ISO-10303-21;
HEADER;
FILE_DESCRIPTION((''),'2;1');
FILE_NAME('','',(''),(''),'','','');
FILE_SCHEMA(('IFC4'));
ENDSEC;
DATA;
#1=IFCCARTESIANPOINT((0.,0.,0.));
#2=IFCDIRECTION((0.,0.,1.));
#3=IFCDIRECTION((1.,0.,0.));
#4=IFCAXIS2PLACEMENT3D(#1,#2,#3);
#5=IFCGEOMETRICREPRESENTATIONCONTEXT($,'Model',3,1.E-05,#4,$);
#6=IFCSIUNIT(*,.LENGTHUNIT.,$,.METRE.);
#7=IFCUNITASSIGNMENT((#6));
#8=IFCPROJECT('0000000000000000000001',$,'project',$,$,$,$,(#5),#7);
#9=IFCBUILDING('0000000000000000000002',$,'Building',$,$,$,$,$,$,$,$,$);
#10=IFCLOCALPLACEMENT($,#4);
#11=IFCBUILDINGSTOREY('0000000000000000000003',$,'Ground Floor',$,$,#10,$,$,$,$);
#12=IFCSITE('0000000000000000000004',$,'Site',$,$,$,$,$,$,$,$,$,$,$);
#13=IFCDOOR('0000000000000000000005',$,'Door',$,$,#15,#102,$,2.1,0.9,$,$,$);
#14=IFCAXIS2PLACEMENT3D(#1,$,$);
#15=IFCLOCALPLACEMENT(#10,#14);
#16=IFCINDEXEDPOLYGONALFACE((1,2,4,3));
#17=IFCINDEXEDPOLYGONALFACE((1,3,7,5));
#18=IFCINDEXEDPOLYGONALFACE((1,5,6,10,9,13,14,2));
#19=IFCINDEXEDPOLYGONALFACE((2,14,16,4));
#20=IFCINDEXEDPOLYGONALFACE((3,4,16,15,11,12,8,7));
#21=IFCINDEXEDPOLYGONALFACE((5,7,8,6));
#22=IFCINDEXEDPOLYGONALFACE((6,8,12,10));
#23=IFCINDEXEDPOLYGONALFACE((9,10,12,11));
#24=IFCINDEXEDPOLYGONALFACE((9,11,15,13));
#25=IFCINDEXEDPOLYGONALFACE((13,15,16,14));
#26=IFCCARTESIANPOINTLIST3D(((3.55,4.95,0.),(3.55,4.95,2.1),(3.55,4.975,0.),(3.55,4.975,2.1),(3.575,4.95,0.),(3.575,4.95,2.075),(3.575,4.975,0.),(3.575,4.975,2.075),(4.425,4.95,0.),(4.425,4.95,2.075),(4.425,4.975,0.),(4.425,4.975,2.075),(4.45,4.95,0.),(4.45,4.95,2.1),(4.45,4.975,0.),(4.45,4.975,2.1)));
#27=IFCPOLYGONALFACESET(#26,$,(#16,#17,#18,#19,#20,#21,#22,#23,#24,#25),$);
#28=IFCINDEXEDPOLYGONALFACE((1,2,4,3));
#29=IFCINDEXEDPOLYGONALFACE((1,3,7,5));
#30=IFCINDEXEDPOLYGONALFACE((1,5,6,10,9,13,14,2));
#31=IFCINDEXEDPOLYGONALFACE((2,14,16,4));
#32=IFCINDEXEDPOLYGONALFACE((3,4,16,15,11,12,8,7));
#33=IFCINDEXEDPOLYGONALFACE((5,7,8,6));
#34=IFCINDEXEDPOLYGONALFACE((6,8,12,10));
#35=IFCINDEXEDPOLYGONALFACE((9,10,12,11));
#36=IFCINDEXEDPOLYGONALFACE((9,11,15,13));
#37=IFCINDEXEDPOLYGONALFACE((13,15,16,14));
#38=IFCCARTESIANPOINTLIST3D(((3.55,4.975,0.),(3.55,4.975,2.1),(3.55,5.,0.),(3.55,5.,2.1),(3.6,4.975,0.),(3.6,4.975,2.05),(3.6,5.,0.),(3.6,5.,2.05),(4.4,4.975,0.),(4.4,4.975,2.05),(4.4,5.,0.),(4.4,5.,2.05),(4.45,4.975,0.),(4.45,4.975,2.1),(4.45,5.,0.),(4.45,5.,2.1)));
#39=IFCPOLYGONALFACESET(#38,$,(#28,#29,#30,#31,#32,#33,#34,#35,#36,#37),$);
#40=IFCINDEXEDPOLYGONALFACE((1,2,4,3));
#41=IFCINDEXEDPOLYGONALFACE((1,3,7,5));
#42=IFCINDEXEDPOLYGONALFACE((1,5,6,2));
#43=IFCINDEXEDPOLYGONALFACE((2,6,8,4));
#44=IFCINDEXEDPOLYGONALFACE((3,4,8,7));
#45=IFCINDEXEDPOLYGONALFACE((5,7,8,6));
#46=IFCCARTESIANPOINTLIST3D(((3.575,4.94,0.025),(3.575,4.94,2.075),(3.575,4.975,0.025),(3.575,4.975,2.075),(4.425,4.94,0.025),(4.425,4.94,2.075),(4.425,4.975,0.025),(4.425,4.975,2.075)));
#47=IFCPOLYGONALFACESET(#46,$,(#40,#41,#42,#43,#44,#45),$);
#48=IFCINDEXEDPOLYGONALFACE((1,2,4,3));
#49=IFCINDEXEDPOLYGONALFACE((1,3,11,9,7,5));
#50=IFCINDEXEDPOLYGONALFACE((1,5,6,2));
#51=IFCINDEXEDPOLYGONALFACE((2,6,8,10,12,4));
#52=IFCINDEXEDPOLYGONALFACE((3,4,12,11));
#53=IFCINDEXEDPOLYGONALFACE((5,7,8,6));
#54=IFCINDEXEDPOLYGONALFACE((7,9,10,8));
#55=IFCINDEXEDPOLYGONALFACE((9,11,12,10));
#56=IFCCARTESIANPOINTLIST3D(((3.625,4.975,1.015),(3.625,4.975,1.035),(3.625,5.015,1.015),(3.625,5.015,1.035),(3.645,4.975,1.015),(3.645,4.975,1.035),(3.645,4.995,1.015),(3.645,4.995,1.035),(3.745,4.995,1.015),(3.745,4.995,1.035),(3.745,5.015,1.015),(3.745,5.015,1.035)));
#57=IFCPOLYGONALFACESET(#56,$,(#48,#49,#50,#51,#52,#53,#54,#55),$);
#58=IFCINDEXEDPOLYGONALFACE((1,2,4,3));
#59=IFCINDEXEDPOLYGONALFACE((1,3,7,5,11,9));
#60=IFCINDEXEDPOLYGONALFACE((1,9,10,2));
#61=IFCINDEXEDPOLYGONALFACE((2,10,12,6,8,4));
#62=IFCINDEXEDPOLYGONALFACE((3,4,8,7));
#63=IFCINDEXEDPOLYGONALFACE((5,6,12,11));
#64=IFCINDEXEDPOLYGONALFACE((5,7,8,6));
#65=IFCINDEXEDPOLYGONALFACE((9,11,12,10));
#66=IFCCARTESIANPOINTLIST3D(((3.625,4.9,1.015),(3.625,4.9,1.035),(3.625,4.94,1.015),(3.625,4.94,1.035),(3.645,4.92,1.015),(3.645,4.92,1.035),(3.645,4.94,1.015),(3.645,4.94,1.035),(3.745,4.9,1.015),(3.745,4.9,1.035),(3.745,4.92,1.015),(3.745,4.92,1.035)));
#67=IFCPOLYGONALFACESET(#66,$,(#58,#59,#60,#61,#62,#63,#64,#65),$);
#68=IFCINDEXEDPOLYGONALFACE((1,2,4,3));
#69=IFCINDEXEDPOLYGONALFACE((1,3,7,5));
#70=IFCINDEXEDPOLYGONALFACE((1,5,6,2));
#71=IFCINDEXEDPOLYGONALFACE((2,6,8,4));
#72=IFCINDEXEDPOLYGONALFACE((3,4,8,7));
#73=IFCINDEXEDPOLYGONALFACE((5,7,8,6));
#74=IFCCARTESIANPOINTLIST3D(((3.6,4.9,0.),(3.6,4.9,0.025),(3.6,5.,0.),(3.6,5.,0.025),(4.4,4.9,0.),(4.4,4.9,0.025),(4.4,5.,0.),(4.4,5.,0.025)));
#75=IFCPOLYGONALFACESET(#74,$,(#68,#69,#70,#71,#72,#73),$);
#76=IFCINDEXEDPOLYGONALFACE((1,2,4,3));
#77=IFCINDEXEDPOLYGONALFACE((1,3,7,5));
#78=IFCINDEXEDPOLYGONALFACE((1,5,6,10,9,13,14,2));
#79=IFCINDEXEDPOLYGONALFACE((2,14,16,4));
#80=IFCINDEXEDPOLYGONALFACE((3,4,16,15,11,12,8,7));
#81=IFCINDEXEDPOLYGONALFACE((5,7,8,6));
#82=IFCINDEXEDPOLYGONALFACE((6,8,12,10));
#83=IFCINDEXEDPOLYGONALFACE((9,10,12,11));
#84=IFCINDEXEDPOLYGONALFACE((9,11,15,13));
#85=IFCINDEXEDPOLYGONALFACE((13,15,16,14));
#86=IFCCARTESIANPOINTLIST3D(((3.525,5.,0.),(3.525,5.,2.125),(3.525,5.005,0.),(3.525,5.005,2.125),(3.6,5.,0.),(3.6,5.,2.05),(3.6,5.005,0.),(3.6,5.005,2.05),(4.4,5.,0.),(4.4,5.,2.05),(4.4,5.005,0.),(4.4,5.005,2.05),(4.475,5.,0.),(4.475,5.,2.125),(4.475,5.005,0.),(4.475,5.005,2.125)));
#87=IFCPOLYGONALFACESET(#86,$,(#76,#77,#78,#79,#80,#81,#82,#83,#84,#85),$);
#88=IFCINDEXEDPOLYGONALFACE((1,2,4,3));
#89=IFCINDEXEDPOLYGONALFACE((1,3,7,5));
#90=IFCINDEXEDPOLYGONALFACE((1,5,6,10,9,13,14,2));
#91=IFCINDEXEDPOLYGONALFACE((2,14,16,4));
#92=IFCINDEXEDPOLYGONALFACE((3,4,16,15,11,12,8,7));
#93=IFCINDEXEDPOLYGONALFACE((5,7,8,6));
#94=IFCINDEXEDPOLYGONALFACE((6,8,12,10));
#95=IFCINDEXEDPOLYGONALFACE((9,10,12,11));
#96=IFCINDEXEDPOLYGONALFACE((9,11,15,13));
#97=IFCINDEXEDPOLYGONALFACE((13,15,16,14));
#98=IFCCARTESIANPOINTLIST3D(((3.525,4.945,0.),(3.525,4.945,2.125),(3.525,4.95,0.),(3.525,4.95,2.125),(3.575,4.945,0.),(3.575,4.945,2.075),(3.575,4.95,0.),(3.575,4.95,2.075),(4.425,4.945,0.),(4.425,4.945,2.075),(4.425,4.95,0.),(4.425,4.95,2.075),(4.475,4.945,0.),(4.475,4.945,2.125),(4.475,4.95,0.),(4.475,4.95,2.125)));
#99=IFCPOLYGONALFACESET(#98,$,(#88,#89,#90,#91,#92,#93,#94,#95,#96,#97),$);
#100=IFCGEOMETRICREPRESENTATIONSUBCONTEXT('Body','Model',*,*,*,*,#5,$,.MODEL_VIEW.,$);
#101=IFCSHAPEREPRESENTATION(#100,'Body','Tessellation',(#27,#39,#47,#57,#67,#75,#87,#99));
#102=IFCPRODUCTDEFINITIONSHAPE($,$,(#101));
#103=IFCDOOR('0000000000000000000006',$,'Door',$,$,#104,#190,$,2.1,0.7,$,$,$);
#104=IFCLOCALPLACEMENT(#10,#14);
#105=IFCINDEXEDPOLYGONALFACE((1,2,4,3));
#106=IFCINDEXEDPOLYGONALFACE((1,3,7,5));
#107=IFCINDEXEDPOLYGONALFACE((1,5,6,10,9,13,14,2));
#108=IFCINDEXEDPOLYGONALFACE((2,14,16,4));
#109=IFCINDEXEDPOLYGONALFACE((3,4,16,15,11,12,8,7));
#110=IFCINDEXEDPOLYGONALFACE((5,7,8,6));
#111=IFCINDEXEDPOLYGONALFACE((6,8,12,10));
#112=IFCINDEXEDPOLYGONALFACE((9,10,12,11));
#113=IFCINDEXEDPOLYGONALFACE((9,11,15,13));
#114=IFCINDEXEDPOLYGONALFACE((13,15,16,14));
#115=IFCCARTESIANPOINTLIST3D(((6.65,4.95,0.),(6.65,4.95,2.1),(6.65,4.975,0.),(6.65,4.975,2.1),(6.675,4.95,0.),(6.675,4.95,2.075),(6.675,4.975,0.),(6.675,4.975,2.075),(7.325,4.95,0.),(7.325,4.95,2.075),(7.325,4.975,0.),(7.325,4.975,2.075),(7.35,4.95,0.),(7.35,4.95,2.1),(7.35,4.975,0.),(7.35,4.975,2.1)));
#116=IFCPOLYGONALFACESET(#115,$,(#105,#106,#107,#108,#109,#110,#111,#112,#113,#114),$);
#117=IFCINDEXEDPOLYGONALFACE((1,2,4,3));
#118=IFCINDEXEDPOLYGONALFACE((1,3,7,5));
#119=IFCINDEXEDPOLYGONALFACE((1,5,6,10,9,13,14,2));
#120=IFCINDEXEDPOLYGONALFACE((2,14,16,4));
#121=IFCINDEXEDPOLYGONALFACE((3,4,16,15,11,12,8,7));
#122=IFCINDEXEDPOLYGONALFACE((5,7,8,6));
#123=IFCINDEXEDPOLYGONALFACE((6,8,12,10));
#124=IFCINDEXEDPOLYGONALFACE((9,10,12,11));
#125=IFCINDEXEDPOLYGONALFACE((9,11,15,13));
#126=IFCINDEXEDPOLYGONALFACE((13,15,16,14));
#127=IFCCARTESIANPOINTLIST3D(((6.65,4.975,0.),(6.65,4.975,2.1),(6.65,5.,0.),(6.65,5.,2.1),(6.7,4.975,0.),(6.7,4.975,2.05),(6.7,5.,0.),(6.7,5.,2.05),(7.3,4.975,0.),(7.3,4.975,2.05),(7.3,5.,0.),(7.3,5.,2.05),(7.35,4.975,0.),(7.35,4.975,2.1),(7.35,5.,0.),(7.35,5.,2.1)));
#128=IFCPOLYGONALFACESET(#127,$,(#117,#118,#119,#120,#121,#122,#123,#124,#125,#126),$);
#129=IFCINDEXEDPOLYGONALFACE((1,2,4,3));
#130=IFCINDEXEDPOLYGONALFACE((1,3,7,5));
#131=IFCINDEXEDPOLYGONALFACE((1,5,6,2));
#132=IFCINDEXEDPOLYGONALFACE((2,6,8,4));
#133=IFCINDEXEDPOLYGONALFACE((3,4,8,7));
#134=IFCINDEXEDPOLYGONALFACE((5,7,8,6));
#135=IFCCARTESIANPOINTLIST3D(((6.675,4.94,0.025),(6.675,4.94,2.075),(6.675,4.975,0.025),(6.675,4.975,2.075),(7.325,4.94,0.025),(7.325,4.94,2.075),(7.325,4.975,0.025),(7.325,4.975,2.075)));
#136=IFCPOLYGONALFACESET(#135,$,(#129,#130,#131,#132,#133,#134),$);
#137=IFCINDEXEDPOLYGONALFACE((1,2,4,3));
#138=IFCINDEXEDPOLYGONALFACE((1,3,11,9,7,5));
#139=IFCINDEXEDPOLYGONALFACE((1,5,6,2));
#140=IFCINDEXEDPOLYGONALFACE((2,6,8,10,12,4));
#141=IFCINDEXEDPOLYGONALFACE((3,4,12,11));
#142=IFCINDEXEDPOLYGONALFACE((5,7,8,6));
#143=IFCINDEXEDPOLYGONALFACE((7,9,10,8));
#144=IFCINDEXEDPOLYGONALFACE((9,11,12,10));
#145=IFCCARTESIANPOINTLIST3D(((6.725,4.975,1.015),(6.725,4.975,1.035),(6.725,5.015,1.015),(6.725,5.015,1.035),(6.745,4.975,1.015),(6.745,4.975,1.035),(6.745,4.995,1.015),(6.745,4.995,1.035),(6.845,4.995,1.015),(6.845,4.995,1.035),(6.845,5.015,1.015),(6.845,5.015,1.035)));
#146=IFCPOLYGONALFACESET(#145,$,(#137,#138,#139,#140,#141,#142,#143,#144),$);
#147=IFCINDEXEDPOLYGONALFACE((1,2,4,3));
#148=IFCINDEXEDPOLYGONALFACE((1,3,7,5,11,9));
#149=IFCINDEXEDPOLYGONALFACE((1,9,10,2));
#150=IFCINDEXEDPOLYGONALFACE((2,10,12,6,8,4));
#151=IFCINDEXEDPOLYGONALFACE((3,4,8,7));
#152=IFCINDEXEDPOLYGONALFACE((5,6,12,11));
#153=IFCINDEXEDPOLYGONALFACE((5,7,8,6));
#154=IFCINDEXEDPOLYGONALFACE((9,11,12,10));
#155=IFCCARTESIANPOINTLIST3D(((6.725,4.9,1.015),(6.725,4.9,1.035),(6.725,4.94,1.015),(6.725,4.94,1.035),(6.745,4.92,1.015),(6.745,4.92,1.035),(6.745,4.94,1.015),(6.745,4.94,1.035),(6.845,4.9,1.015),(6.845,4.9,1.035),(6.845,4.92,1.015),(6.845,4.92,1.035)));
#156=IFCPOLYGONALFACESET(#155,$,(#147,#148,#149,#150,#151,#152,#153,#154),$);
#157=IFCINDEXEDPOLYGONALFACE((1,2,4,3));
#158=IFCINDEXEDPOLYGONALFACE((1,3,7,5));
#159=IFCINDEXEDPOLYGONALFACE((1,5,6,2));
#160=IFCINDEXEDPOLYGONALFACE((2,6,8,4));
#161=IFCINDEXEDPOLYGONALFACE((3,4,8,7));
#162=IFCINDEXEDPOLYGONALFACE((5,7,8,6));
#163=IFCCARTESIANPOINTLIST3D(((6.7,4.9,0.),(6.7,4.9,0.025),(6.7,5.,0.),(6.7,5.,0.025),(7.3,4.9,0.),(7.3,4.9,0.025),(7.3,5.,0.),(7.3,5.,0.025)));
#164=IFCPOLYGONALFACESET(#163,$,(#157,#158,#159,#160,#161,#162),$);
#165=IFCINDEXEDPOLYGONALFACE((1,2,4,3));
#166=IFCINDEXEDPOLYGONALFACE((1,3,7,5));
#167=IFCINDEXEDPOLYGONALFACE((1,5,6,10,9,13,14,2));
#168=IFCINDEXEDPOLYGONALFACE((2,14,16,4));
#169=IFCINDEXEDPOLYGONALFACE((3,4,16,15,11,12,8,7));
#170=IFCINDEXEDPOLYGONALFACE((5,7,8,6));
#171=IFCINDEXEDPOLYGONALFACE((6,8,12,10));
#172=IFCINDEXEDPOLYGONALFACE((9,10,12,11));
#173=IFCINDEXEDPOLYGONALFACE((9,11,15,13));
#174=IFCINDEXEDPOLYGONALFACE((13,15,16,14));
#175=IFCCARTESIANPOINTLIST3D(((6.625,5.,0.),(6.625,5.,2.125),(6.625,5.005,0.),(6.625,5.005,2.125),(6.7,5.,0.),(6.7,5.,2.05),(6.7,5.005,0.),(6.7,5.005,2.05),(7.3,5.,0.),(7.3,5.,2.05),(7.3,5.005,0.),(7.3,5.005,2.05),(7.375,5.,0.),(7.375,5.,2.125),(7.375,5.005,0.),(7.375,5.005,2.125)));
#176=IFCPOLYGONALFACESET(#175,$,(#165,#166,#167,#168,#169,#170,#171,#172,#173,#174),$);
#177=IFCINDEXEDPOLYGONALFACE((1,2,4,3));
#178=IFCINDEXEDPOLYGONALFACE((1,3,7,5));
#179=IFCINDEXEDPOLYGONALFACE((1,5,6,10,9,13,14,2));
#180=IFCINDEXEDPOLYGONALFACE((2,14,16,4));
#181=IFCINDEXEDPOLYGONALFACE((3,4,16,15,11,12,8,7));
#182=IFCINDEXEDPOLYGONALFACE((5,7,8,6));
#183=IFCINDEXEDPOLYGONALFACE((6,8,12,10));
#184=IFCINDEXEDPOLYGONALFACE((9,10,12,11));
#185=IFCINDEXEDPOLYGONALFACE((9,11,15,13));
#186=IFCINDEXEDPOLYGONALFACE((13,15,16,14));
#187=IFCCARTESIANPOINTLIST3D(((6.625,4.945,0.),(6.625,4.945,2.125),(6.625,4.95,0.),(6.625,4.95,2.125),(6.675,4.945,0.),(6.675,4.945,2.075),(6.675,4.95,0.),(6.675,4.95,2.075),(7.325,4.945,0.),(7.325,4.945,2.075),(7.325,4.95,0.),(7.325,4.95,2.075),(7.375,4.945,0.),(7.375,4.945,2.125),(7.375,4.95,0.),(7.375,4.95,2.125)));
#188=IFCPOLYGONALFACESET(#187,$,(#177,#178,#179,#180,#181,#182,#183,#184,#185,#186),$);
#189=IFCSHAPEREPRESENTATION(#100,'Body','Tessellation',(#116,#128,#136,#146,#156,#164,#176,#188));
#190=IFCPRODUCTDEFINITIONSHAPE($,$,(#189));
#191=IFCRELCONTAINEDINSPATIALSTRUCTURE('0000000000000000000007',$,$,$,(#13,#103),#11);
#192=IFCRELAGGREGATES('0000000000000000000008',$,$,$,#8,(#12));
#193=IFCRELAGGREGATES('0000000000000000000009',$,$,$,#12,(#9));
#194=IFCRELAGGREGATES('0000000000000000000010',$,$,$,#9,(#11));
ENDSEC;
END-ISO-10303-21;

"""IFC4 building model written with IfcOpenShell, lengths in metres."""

from ifc_helpers import new_model, si_unit, frame, origin_with_axes, place, context, subcontext, project, spatial, line, indexed_curve, outline, extrude, element, save


model = new_model("IFC4")

# Units and contexts
model_context = context("Model", 3, precision=1e-05, world=origin_with_axes())
body_context = subcontext(model_context, "Body", "Model", "MODEL_VIEW")
ifc_project = project(units=[si_unit("LENGTHUNIT", "METRE")], contexts=[model_context])

# Site, building, storey
site = spatial("IfcSite", under=ifc_project, Name="Site")
building = spatial("IfcBuilding", under=site, Name="Building")
storey_placement = place(None, origin_with_axes())
storey = spatial("IfcBuildingStorey", under=building, at=storey_placement, Name="Ground Floor")

# Doors
door_1_placement = place(storey_placement, frame((4.45, 5.0, 0.0), z_axis=(0.0, 0.0, 1.0), x_axis=(-1.0, 0.0, 0.0)))
element("IfcDoor", 1, at=door_1_placement, inside=storey, Name="Door", OverallHeight=2.1, OverallWidth=0.9, context=body_context, shape_type="SweptSolid", body=[
    extrude(outline(indexed_curve([(0.0, 0.0), (0.0, 2.1), (0.9, 2.1), (0.9, 0.0), (0.875, 0.0), (0.875, 2.075), (0.025, 2.075), (0.025, 0.0)], segments=[line(1, 2, 3, 4, 5, 6, 7, 8, 1)])), frame((0.0, 0.025, 0.0), z_axis=(0.0, -1.0, 0.0), x_axis=(1.0, 0.0, 0.0)), (0.0, 0.0, -1.0), 0.025),
    extrude(outline(indexed_curve([(0.0, 0.0), (0.0, 2.1), (0.9, 2.1), (0.9, 0.0), (0.85, 0.0), (0.85, 2.05), (0.05, 2.05), (0.05, 0.0)], segments=[line(1, 2, 3, 4, 5, 6, 7, 8, 1)])), frame((0.0, 0.0, 0.0), z_axis=(0.0, -1.0, 0.0), x_axis=(1.0, 0.0, 0.0)), (0.0, 0.0, -1.0), 0.025),
    extrude(outline(indexed_curve([(0.0, 0.0), (0.85, 0.0), (0.85, 0.035), (0.0, 0.035)], segments=[line(1, 2, 3, 4, 1)])), frame((0.025, 0.025, 0.025), z_axis=(0.0, 0.0, 1.0), x_axis=(1.0, 0.0, 0.0)), (0.0, 0.0, 1.0), 2.05),
    extrude(outline(indexed_curve([(0.0, 0.0), (0.0, -0.04), (-0.12, -0.04), (-0.12, -0.02), (-0.02, -0.02), (-0.02, 0.0)], segments=[line(1, 2, 3, 4, 5, 6, 1)])), frame((0.825, 0.025, 1.015), z_axis=(0.0, 0.0, 1.0), x_axis=(1.0, 0.0, 0.0)), (0.0, 0.0, 1.0), 0.02),
    extrude(outline(indexed_curve([(0.0, 0.0), (0.0, 0.04), (-0.12, 0.04), (-0.12, 0.02), (-0.02, 0.02), (-0.02, 0.0)], segments=[line(1, 2, 3, 4, 5, 6, 1)])), frame((0.825, 0.06, 1.015), z_axis=(0.0, 0.0, 1.0), x_axis=(1.0, 0.0, 0.0)), (0.0, 0.0, 1.0), 0.02),
    extrude(outline(indexed_curve([(0.0, 0.0), (0.8, 0.0), (0.8, 0.1), (0.0, 0.1)], segments=[line(1, 2, 3, 4, 1)])), frame((0.05, 0.0, 0.0), z_axis=(0.0, 0.0, 1.0), x_axis=(1.0, 0.0, 0.0)), (0.0, 0.0, 1.0), 0.025),
    extrude(outline(indexed_curve([(0.0, 0.0), (0.0, 2.125), (0.95, 2.125), (0.95, 0.0), (0.875, 0.0), (0.875, 2.05), (0.075, 2.05), (0.075, 0.0)], segments=[line(1, 2, 3, 4, 5, 6, 7, 8, 1)])), frame((-0.025, -0.005, 0.0), z_axis=(0.0, -1.0, 0.0), x_axis=(1.0, 0.0, 0.0)), (0.0, 0.0, -1.0), 0.005),
    extrude(outline(indexed_curve([(0.0, 0.0), (0.0, 2.125), (0.95, 2.125), (0.95, 0.0), (0.9, 0.0), (0.9, 2.075), (0.05, 2.075), (0.05, 0.0)], segments=[line(1, 2, 3, 4, 5, 6, 7, 8, 1)])), frame((-0.025, 0.05, 0.0), z_axis=(0.0, -1.0, 0.0), x_axis=(1.0, 0.0, 0.0)), (0.0, 0.0, -1.0), 0.005),
])
door_2_placement = place(storey_placement, frame((7.35, 5.0, 0.0), z_axis=(0.0, 0.0, 1.0), x_axis=(-1.0, 0.0, 0.0)))
element("IfcDoor", 2, at=door_2_placement, inside=storey, Name="Door", OverallHeight=2.1, OverallWidth=0.7, context=body_context, shape_type="SweptSolid", body=[
    extrude(outline(indexed_curve([(0.0, 0.0), (0.0, 2.1), (0.7, 2.1), (0.7, 0.0), (0.675, 0.0), (0.675, 2.075), (0.025, 2.075), (0.025, 0.0)], segments=[line(1, 2, 3, 4, 5, 6, 7, 8, 1)])), frame((0.0, 0.025, 0.0), z_axis=(0.0, -1.0, 0.0), x_axis=(1.0, 0.0, 0.0)), (0.0, 0.0, -1.0), 0.025),
    extrude(outline(indexed_curve([(0.0, 0.0), (0.0, 2.1), (0.7, 2.1), (0.7, 0.0), (0.65, 0.0), (0.65, 2.05), (0.05, 2.05), (0.05, 0.0)], segments=[line(1, 2, 3, 4, 5, 6, 7, 8, 1)])), frame((0.0, 0.0, 0.0), z_axis=(0.0, -1.0, 0.0), x_axis=(1.0, 0.0, 0.0)), (0.0, 0.0, -1.0), 0.025),
    extrude(outline(indexed_curve([(0.0, 0.0), (0.65, 0.0), (0.65, 0.035), (0.0, 0.035)], segments=[line(1, 2, 3, 4, 1)])), frame((0.025, 0.025, 0.025), z_axis=(0.0, 0.0, 1.0), x_axis=(1.0, 0.0, 0.0)), (0.0, 0.0, 1.0), 2.05),
    extrude(outline(indexed_curve([(0.0, 0.0), (0.0, -0.04), (-0.12, -0.04), (-0.12, -0.02), (-0.02, -0.02), (-0.02, 0.0)], segments=[line(1, 2, 3, 4, 5, 6, 1)])), frame((0.625, 0.025, 1.015), z_axis=(0.0, 0.0, 1.0), x_axis=(1.0, 0.0, 0.0)), (0.0, 0.0, 1.0), 0.02),
    extrude(outline(indexed_curve([(0.0, 0.0), (0.0, 0.04), (-0.12, 0.04), (-0.12, 0.02), (-0.02, 0.02), (-0.02, 0.0)], segments=[line(1, 2, 3, 4, 5, 6, 1)])), frame((0.625, 0.06, 1.015), z_axis=(0.0, 0.0, 1.0), x_axis=(1.0, 0.0, 0.0)), (0.0, 0.0, 1.0), 0.02),
    extrude(outline(indexed_curve([(0.0, 0.0), (0.6, 0.0), (0.6, 0.1), (0.0, 0.1)], segments=[line(1, 2, 3, 4, 1)])), frame((0.05, 0.0, 0.0), z_axis=(0.0, 0.0, 1.0), x_axis=(1.0, 0.0, 0.0)), (0.0, 0.0, 1.0), 0.025),
    extrude(outline(indexed_curve([(0.0, 0.0), (0.0, 2.125), (0.75, 2.125), (0.75, 0.0), (0.675, 0.0), (0.675, 2.05), (0.075, 2.05), (0.075, 0.0)], segments=[line(1, 2, 3, 4, 5, 6, 7, 8, 1)])), frame((-0.025, -0.005, 0.0), z_axis=(0.0, -1.0, 0.0), x_axis=(1.0, 0.0, 0.0)), (0.0, 0.0, -1.0), 0.005),
    extrude(outline(indexed_curve([(0.0, 0.0), (0.0, 2.125), (0.75, 2.125), (0.75, 0.0), (0.7, 0.0), (0.7, 2.075), (0.05, 2.075), (0.05, 0.0)], segments=[line(1, 2, 3, 4, 5, 6, 7, 8, 1)])), frame((-0.025, 0.05, 0.0), z_axis=(0.0, -1.0, 0.0), x_axis=(1.0, 0.0, 0.0)), (0.0, 0.0, -1.0), 0.005),
])

save(model, "model.ifc")
